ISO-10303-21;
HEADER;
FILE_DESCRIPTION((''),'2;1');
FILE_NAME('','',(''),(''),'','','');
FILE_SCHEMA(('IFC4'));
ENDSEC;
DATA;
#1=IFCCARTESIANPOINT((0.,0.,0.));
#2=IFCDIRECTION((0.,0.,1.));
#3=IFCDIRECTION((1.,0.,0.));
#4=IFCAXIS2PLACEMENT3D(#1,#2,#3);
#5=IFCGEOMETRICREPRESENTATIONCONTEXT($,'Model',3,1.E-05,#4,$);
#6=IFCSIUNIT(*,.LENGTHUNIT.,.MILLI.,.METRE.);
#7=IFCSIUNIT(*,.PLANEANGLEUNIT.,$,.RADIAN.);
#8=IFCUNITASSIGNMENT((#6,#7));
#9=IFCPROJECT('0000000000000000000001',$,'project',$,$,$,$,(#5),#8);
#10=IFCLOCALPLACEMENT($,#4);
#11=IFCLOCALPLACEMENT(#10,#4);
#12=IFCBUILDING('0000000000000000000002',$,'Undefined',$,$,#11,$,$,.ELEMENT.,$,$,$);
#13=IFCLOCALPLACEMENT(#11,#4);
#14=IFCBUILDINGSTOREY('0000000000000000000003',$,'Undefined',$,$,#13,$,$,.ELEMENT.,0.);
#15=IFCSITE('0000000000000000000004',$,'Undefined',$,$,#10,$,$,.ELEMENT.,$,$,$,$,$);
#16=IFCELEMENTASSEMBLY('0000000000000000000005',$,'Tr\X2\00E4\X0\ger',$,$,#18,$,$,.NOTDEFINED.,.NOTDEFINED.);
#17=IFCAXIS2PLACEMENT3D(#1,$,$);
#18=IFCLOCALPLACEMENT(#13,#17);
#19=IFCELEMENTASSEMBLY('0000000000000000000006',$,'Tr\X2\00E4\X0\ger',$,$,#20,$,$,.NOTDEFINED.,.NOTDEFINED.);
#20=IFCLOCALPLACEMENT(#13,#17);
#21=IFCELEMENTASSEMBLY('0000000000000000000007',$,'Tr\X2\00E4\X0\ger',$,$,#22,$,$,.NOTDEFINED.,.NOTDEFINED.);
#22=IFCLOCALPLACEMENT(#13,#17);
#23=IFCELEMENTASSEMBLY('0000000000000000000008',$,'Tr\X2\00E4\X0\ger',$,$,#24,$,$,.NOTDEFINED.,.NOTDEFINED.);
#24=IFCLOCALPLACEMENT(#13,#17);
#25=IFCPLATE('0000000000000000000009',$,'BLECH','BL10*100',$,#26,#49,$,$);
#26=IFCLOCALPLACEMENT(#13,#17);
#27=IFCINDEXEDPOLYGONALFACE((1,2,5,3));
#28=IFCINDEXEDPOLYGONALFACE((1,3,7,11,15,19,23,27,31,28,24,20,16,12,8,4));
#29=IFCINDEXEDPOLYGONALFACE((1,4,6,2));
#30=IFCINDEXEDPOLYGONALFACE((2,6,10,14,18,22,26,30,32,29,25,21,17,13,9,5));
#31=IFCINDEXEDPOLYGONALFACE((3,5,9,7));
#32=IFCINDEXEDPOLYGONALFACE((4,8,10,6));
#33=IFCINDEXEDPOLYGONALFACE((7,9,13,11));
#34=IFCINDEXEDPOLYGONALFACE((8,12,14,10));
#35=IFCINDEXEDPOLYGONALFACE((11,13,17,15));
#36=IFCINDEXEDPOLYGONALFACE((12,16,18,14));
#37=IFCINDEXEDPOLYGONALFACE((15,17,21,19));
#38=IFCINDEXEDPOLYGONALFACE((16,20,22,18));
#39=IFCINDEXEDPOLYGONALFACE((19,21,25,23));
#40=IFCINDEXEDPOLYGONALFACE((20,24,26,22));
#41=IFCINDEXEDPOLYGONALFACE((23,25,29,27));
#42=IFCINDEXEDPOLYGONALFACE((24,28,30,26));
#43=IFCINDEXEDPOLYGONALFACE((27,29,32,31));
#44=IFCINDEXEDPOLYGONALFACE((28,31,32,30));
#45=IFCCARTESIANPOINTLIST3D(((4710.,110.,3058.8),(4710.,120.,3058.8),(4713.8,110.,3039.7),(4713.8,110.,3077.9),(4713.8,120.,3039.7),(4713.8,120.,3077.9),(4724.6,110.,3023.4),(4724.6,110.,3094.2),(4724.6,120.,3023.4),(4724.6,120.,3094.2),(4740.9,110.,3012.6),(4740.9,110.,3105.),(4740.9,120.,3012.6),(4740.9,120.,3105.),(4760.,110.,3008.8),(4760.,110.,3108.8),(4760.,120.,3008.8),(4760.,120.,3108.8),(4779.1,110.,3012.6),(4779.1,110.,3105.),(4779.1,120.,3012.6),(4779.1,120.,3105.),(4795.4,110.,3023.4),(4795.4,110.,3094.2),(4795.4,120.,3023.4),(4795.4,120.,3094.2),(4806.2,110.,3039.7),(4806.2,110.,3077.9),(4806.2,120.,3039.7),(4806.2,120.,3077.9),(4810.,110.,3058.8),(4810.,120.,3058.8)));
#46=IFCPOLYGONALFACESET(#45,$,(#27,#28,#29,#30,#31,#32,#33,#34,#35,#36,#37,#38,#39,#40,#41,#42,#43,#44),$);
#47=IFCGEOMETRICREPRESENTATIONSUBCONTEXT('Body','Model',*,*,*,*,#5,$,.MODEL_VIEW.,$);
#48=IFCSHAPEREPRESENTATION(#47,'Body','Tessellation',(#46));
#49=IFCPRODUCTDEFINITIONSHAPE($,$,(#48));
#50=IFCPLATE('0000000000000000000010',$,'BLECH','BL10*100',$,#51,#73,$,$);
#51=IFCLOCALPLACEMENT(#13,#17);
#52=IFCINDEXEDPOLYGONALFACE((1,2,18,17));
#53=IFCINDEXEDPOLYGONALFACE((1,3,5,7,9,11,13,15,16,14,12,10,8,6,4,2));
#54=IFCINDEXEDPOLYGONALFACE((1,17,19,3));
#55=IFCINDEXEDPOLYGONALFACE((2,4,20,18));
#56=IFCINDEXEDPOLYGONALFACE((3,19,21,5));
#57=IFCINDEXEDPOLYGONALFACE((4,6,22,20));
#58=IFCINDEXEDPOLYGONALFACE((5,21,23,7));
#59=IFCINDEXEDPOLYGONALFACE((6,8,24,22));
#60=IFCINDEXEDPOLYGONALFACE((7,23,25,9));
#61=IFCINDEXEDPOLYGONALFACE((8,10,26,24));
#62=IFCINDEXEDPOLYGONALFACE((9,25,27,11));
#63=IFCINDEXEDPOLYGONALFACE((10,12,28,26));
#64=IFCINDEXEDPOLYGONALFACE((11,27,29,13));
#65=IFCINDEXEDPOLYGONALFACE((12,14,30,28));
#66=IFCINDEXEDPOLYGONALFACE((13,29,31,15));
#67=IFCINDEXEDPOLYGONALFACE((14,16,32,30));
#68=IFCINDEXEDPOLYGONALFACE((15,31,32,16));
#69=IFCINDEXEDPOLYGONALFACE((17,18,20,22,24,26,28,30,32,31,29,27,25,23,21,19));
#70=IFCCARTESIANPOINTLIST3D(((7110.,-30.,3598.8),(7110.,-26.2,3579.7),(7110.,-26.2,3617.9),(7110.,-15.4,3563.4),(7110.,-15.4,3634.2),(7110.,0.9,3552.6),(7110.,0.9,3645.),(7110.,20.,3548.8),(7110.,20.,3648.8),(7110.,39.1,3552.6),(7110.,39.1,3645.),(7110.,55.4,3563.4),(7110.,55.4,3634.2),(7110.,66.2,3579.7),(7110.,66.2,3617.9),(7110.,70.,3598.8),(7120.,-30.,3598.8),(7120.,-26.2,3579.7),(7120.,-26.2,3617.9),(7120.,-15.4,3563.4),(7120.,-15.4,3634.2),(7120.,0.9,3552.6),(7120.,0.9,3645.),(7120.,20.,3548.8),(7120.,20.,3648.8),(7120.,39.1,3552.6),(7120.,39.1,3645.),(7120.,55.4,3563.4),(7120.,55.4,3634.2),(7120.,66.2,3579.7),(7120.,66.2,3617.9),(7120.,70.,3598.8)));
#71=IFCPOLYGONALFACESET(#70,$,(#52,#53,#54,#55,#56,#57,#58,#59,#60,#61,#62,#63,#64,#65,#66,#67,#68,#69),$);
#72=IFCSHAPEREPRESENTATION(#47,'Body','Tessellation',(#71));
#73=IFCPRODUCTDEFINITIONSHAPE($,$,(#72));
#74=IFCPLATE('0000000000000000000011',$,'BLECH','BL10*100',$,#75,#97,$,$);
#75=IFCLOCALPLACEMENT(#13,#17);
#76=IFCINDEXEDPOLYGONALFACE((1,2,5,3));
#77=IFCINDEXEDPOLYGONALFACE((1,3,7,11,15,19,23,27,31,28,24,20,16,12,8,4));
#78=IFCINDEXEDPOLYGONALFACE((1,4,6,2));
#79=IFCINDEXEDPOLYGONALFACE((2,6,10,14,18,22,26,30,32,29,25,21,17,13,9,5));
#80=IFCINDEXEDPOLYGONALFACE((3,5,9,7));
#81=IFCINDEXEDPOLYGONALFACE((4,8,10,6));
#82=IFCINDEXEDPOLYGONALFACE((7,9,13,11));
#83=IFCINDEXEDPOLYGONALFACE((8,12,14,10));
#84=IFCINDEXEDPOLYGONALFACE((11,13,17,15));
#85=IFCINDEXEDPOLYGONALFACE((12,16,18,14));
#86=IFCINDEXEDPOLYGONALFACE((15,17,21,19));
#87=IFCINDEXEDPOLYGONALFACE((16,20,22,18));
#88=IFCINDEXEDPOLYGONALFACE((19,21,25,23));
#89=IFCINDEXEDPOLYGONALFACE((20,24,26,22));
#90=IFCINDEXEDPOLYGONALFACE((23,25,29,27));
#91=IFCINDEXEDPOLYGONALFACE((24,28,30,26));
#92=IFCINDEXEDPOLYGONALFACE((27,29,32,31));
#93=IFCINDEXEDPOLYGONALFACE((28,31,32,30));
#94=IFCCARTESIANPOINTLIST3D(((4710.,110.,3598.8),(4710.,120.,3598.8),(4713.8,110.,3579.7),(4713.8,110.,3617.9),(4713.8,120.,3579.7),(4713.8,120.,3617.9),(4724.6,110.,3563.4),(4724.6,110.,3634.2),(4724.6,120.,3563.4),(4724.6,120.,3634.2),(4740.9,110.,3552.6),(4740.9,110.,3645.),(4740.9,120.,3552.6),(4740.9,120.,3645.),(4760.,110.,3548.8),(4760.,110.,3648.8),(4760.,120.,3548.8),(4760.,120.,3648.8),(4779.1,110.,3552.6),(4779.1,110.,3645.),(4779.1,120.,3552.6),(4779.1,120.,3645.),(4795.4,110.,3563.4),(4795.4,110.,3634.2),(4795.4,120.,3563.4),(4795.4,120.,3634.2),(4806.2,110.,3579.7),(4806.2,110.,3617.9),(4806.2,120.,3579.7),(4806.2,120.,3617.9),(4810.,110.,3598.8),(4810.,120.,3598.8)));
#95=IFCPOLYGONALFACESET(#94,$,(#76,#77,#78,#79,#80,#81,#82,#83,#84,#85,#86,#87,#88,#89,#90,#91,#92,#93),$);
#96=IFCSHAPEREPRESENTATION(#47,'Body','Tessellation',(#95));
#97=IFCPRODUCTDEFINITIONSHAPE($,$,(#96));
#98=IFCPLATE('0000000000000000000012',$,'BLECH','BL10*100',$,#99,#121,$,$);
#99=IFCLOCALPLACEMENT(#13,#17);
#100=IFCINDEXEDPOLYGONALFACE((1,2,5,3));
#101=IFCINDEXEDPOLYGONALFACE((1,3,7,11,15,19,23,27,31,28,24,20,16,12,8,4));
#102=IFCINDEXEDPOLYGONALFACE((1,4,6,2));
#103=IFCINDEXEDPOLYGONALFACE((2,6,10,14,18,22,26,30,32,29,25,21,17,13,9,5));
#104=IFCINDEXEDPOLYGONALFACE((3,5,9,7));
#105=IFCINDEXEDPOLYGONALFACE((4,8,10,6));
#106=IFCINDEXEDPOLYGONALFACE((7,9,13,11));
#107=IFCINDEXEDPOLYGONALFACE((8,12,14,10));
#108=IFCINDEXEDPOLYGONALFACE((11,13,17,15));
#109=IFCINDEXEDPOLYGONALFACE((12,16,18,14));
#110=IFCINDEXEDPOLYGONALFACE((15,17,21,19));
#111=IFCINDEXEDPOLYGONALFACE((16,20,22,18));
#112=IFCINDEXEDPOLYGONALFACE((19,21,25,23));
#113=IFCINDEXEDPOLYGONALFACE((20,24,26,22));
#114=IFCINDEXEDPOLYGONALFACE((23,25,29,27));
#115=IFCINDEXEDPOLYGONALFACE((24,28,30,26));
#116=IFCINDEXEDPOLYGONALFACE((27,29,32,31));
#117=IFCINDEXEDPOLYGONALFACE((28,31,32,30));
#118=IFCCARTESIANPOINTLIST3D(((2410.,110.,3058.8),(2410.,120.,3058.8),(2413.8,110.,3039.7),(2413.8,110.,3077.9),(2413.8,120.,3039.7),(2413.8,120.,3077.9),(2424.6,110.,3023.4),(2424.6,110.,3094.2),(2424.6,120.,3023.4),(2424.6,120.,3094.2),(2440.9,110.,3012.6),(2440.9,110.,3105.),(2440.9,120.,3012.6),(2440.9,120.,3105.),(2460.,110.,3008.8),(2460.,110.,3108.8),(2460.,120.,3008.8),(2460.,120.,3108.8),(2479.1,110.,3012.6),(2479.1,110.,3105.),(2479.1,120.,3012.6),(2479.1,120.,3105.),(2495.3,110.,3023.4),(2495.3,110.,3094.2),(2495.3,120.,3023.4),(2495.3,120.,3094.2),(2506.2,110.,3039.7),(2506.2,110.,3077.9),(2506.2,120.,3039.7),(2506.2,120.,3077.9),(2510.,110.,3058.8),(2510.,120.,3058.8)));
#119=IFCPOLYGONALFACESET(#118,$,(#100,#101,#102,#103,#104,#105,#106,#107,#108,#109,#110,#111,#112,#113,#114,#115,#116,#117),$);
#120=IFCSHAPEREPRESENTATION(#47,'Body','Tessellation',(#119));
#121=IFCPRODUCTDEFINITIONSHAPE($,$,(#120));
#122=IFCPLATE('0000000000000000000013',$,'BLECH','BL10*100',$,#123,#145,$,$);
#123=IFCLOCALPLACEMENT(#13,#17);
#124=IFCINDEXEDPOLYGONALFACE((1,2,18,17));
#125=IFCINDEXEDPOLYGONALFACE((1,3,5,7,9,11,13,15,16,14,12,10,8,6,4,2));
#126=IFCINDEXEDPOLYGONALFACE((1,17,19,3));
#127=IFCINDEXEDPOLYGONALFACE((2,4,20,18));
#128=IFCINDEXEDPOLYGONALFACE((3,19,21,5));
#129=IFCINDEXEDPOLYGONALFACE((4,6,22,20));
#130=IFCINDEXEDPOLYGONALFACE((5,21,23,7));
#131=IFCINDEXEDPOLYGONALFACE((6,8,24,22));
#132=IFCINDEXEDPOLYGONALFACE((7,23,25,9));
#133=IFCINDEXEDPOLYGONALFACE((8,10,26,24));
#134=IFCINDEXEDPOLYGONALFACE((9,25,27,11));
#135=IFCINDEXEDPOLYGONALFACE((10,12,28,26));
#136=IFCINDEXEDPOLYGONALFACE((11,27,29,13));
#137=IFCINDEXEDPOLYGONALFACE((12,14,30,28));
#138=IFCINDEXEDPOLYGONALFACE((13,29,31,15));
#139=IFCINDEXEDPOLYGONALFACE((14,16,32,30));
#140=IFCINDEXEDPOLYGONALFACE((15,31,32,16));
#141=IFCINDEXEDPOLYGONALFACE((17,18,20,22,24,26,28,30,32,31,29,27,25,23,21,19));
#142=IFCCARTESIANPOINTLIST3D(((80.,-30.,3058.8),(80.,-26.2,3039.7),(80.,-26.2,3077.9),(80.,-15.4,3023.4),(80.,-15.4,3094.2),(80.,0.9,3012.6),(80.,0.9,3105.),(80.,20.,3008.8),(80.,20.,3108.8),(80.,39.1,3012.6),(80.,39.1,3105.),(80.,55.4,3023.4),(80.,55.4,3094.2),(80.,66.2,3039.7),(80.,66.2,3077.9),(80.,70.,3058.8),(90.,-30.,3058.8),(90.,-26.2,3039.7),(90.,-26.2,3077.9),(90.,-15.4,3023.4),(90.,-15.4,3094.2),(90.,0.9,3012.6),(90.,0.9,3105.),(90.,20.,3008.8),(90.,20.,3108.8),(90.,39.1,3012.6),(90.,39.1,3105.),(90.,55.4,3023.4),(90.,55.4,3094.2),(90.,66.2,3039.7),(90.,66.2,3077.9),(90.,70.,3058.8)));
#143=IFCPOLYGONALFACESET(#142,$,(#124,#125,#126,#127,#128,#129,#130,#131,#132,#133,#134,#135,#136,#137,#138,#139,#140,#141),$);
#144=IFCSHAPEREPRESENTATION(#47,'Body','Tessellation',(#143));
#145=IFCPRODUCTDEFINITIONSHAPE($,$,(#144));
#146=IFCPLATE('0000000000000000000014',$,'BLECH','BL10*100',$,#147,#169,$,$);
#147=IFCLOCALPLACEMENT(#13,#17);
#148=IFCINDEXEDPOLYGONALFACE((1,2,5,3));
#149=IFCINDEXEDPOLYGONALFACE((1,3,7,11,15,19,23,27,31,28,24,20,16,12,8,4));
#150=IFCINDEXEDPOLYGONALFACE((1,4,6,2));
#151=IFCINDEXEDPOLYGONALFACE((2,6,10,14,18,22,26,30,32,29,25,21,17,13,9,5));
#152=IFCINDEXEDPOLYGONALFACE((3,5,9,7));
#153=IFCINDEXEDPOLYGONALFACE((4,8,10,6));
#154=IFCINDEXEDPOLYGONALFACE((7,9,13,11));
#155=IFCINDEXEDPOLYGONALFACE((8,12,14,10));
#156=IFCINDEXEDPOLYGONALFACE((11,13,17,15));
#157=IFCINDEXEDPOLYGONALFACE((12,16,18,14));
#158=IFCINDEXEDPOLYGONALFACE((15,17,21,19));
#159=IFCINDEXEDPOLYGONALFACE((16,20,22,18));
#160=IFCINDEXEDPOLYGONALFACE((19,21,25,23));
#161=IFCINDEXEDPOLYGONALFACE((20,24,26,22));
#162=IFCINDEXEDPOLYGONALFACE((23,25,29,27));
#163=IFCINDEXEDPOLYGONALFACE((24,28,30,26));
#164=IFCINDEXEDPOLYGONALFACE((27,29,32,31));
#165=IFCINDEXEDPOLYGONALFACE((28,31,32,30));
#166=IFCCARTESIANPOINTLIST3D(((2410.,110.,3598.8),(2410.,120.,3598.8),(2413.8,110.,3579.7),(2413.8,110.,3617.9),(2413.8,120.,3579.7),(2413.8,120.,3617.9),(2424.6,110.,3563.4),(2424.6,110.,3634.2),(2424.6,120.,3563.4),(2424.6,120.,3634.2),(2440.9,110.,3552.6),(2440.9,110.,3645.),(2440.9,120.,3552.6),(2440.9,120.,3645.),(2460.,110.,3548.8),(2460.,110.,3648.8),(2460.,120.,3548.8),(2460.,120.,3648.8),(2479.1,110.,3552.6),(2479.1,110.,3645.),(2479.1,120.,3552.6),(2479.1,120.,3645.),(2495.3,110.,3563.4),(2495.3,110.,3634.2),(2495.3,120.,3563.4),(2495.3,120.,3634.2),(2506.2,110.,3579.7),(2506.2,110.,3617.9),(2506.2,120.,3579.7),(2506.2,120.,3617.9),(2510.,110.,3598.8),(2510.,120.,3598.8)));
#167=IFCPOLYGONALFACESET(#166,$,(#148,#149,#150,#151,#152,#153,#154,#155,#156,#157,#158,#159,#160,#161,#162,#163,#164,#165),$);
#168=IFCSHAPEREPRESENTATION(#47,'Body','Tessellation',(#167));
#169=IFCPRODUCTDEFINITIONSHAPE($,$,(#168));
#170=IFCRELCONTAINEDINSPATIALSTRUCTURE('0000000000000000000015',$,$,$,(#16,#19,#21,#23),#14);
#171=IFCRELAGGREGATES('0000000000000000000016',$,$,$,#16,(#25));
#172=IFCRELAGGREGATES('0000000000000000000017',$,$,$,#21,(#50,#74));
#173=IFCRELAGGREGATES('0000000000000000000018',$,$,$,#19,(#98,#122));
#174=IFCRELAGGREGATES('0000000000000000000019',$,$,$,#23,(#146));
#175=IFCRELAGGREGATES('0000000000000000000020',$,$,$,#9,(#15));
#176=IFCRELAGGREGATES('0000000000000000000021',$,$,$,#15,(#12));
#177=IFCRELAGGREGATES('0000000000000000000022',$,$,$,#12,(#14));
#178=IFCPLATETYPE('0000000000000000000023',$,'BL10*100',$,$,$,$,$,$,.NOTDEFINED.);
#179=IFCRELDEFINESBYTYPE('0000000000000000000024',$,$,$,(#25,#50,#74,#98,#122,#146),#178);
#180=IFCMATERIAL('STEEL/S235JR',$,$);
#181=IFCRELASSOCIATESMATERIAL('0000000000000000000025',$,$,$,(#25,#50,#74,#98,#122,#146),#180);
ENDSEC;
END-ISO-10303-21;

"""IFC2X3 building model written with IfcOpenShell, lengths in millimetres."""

from ifc_helpers import new_model, si_unit, frame, origin_with_axes, place, context, subcontext, project, spatial, polyline, outline, extrude, material, type_object, element, aggregate, save


model = new_model("IFC2X3")

# Units and contexts
model_context = context("Model", 3, precision=1e-05, world=origin_with_axes())
body_context = subcontext(model_context, "Body", "Model", "MODEL_VIEW")
ifc_project = project(units=[si_unit("LENGTHUNIT", "METRE", prefix="MILLI"), si_unit("PLANEANGLEUNIT", "RADIAN")], contexts=[model_context])

# Site, building, storey
site_placement = place(None, origin_with_axes())
site = spatial("IfcSite", under=ifc_project, at=site_placement, Name="Undefined", CompositionType="ELEMENT")
building_placement = place(site_placement, origin_with_axes())
building = spatial("IfcBuilding", under=site, at=building_placement, Name="Undefined", CompositionType="ELEMENT")
storey_placement = place(building_placement, origin_with_axes())
storey = spatial("IfcBuildingStorey", under=building, at=storey_placement, Name="Undefined", CompositionType="ELEMENT", Elevation=0.0)

# Element assembly
assembly_1_placement = place(storey_placement, origin_with_axes())
assembly_1 = element("IfcElementAssembly", 1, at=assembly_1_placement, inside=storey, Name="Träger", AssemblyPlace="NOTDEFINED", PredefinedType="NOTDEFINED")
ifc_material = material(Name="STEEL/S235JR")

# Element assembly
assembly_2_placement = place(storey_placement, origin_with_axes())
assembly_2 = element("IfcElementAssembly", 2, at=assembly_2_placement, inside=storey, Name="Träger", AssemblyPlace="NOTDEFINED", PredefinedType="NOTDEFINED")

# Element assembly
assembly_3_placement = place(storey_placement, origin_with_axes())
assembly_3 = element("IfcElementAssembly", 3, at=assembly_3_placement, inside=storey, Name="Träger", AssemblyPlace="NOTDEFINED", PredefinedType="NOTDEFINED")

# Element assembly
assembly_4_placement = place(storey_placement, origin_with_axes())
assembly_4 = element("IfcElementAssembly", 4, at=assembly_4_placement, inside=storey, Name="Träger", AssemblyPlace="NOTDEFINED", PredefinedType="NOTDEFINED")

# Plates
plate_type_1 = type_object("IfcPlateType", Name="BL10*100", PredefinedType="NOTDEFINED")
plate_1_placement = place(assembly_1_placement, frame((4710.0, 115.0, 3008.8), z_axis=(0.0, -1.0, 0.0), x_axis=(1.0, 0.0, 0.0)))
plate_1 = element("IfcPlate", 5, at=plate_1_placement, type_object=plate_type_1, material=ifc_material, Name="BLECH", Description="BL10*100", context=body_context, shape_type="SweptSolid", body=[
    extrude(outline(polyline([(0.0, 50.0), (3.8, 30.9), (14.6, 14.6), (30.9, 3.8), (50.0, 0.0), (50.0, 0.0), (69.1, 3.8), (85.4, 14.6), (96.2, 30.9), (100.0, 50.0), (100.0, 50.0), (96.2, 69.1), (85.4, 85.4), (69.1, 96.2), (50.0, 100.0), (50.0, 100.0), (30.9, 96.2), (14.6, 85.4), (3.8, 69.1), (0.0, 50.0), (0.0, 50.0)])), frame((0.0, 0.0, -5.0), z_axis=(0.0, 0.0, 1.0), x_axis=(1.0, 0.0, 0.0)), (0.0, 0.0, 1.0), 10.0),
])
aggregate(assembly_1, [plate_1])
plate_2_placement = place(assembly_3_placement, frame((7115.0, 70.0, 3648.8), z_axis=(1.0, 0.0, 0.0), x_axis=(0.0, -1.0, 0.0)))
plate_2 = element("IfcPlate", 6, at=plate_2_placement, type_object=plate_type_1, material=ifc_material, Name="BLECH", Description="BL10*100", context=body_context, shape_type="SweptSolid", body=[
    extrude(outline(polyline([(0.0, 50.0), (3.8, 30.9), (14.6, 14.6), (30.9, 3.8), (50.0, 0.0), (50.0, 0.0), (69.1, 3.8), (85.4, 14.6), (96.2, 30.9), (100.0, 50.0), (100.0, 50.0), (96.2, 69.1), (85.4, 85.4), (69.1, 96.2), (50.0, 100.0), (50.0, 100.0), (30.9, 96.2), (14.6, 85.4), (3.8, 69.1), (0.0, 50.0), (0.0, 50.0)])), frame((0.0, 0.0, -5.0), z_axis=(0.0, 0.0, 1.0), x_axis=(1.0, 0.0, 0.0)), (0.0, 0.0, 1.0), 10.0),
])
plate_3_placement = place(assembly_3_placement, frame((4710.0, 115.0, 3548.8), z_axis=(0.0, -1.0, 0.0), x_axis=(1.0, 0.0, 0.0)))
plate_3 = element("IfcPlate", 7, at=plate_3_placement, type_object=plate_type_1, material=ifc_material, Name="BLECH", Description="BL10*100", context=body_context, shape_type="SweptSolid", body=[
    extrude(outline(polyline([(0.0, 50.0), (3.8, 30.9), (14.6, 14.6), (30.9, 3.8), (50.0, 0.0), (50.0, 0.0), (69.1, 3.8), (85.4, 14.6), (96.2, 30.9), (100.0, 50.0), (100.0, 50.0), (96.2, 69.1), (85.4, 85.4), (69.1, 96.2), (50.0, 100.0), (50.0, 100.0), (30.9, 96.2), (14.6, 85.4), (3.8, 69.1), (0.0, 50.0), (0.0, 50.0)])), frame((0.0, 0.0, -5.0), z_axis=(0.0, 0.0, 1.0), x_axis=(1.0, 0.0, 0.0)), (0.0, 0.0, 1.0), 10.0),
])
aggregate(assembly_3, [plate_2, plate_3])
plate_4_placement = place(assembly_2_placement, frame((2410.0, 115.0, 3008.8), z_axis=(0.0, -1.0, 0.0), x_axis=(1.0, 0.0, 0.0)))
plate_4 = element("IfcPlate", 8, at=plate_4_placement, type_object=plate_type_1, material=ifc_material, Name="BLECH", Description="BL10*100", context=body_context, shape_type="SweptSolid", body=[
    extrude(outline(polyline([(0.0, 50.0), (3.8, 30.9), (14.6, 14.6), (30.9, 3.8), (50.0, 0.0), (50.0, 0.0), (69.1, 3.8), (85.4, 14.6), (96.2, 30.9), (100.0, 50.0), (100.0, 50.0), (96.2, 69.1), (85.4, 85.4), (69.1, 96.2), (50.0, 100.0), (50.0, 100.0), (30.9, 96.2), (14.6, 85.4), (3.8, 69.1), (0.0, 50.0), (0.0, 50.0)])), frame((0.0, 0.0, -5.0), z_axis=(0.0, 0.0, 1.0), x_axis=(1.0, 0.0, 0.0)), (0.0, 0.0, 1.0), 10.0),
])
plate_5_placement = place(assembly_2_placement, frame((85.0, 70.0, 3108.8), z_axis=(1.0, 0.0, 0.0), x_axis=(0.0, -1.0, 0.0)))
plate_5 = element("IfcPlate", 9, at=plate_5_placement, type_object=plate_type_1, material=ifc_material, Name="BLECH", Description="BL10*100", context=body_context, shape_type="SweptSolid", body=[
    extrude(outline(polyline([(0.0, 50.0), (3.8, 30.9), (14.6, 14.6), (30.9, 3.8), (50.0, 0.0), (50.0, 0.0), (69.1, 3.8), (85.4, 14.6), (96.2, 30.9), (100.0, 50.0), (100.0, 50.0), (96.2, 69.1), (85.4, 85.4), (69.1, 96.2), (50.0, 100.0), (50.0, 100.0), (30.9, 96.2), (14.6, 85.4), (3.8, 69.1), (0.0, 50.0), (0.0, 50.0)])), frame((0.0, 0.0, -5.0), z_axis=(0.0, 0.0, 1.0), x_axis=(1.0, 0.0, 0.0)), (0.0, 0.0, 1.0), 10.0),
])
aggregate(assembly_2, [plate_4, plate_5])
plate_6_placement = place(assembly_4_placement, frame((2410.0, 115.0, 3548.8), z_axis=(0.0, -1.0, 0.0), x_axis=(1.0, 0.0, 0.0)))
plate_6 = element("IfcPlate", 10, at=plate_6_placement, type_object=plate_type_1, material=ifc_material, Name="BLECH", Description="BL10*100", context=body_context, shape_type="SweptSolid", body=[
    extrude(outline(polyline([(0.0, 50.0), (3.8, 30.9), (14.6, 14.6), (30.9, 3.8), (50.0, 0.0), (50.0, 0.0), (69.1, 3.8), (85.4, 14.6), (96.2, 30.9), (100.0, 50.0), (100.0, 50.0), (96.2, 69.1), (85.4, 85.4), (69.1, 96.2), (50.0, 100.0), (50.0, 100.0), (30.9, 96.2), (14.6, 85.4), (3.8, 69.1), (0.0, 50.0), (0.0, 50.0)])), frame((0.0, 0.0, -5.0), z_axis=(0.0, 0.0, 1.0), x_axis=(1.0, 0.0, 0.0)), (0.0, 0.0, 1.0), 10.0),
])
aggregate(assembly_4, [plate_6])

save(model, "model.ifc")
